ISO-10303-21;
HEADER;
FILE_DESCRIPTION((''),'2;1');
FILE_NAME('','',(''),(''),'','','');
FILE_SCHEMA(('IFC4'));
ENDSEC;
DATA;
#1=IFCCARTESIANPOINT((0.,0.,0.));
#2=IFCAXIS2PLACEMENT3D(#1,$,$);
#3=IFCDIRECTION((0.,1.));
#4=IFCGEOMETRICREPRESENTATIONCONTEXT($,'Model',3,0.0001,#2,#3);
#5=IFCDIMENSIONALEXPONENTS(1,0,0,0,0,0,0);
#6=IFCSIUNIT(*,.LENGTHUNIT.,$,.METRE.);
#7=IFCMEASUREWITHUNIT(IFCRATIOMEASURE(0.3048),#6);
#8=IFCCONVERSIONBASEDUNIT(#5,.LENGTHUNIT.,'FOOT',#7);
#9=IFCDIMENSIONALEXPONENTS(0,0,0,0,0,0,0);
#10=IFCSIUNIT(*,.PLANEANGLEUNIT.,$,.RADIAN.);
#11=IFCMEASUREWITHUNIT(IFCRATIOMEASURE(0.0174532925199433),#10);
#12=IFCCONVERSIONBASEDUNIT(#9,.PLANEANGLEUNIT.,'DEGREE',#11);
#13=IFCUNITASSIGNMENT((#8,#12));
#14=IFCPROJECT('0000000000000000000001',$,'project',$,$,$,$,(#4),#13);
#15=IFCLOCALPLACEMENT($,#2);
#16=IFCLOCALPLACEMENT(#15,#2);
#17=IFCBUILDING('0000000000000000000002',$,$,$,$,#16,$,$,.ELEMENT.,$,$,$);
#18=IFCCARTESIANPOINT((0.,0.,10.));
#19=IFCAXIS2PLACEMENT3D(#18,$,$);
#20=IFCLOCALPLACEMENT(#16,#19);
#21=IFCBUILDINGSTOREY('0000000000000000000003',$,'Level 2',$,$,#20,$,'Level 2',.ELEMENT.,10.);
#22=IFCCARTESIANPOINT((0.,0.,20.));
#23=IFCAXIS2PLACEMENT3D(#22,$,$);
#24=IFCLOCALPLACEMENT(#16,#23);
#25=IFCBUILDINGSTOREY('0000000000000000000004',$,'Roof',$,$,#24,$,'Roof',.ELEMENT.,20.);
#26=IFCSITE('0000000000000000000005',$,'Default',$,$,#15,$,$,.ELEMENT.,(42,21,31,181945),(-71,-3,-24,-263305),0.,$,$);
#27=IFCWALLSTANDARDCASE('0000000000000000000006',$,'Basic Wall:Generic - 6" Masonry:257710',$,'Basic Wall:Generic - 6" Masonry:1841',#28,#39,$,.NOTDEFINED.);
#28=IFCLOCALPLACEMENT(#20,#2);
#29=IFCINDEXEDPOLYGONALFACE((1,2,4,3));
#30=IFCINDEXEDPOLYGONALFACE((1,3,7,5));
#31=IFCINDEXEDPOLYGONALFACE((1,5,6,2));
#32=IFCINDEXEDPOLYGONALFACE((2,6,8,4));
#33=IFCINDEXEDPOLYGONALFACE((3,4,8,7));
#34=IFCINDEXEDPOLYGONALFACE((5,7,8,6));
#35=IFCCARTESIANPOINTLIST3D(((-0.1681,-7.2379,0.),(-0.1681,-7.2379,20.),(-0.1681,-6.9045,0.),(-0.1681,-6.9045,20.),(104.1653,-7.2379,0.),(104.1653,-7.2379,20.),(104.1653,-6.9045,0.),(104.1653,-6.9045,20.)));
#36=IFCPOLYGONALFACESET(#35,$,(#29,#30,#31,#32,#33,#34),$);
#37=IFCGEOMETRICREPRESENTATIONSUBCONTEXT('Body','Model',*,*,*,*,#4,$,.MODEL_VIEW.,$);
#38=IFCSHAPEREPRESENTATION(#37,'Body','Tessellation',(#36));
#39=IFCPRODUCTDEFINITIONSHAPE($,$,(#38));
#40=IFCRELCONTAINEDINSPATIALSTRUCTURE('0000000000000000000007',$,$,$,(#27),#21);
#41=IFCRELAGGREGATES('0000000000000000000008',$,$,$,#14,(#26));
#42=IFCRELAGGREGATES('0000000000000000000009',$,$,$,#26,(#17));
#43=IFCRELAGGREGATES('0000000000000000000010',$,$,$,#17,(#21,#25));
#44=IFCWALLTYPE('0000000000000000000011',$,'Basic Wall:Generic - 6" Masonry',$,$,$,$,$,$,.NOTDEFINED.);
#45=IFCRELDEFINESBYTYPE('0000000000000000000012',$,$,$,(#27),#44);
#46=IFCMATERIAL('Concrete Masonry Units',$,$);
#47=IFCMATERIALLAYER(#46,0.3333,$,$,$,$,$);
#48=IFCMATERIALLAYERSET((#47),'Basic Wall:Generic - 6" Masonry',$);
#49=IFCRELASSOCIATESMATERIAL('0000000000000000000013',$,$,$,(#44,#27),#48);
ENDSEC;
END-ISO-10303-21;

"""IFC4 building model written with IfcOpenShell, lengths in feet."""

from ifc_helpers import new_model, entity, si_unit, converted_unit, direction, frame, frame_2d, origin, place, context, subcontext, project, spatial, rectangle, extrude, material, layer, layer_set, layer_usage, type_object, element, save


model = new_model("IFC4")

# Units and contexts
model_context = context("Model", 3, precision=0.0001, world=origin(), true_north=direction((0.0, 1.0)))
body_context = subcontext(model_context, "Body", "Model", "MODEL_VIEW")
ifc_project = project(units=[converted_unit("LENGTHUNIT", "FOOT", entity("IfcRatioMeasure", 0.3048), si_unit("LENGTHUNIT", "METRE"), dimensions=[1, 0, 0, 0, 0, 0, 0]), converted_unit("PLANEANGLEUNIT", "DEGREE", entity("IfcRatioMeasure", 0.0174532925199433), si_unit("PLANEANGLEUNIT", "RADIAN"), dimensions=[0, 0, 0, 0, 0, 0, 0])], contexts=[model_context])

# Site, building, storey
site_placement = place(None, origin())
site = spatial("IfcSite", under=ifc_project, at=site_placement, Name="Default", CompositionType="ELEMENT", RefLatitude=(42, 21, 31, 181945), RefLongitude=(-71, -3, -24, -263305), RefElevation=0.0)
building_placement = place(site_placement, origin())
building = spatial("IfcBuilding", under=site, at=building_placement, CompositionType="ELEMENT")
storey_1_placement = place(building_placement, frame((0.0, 0.0, 10.0)))
storey_1 = spatial("IfcBuildingStorey", under=building, at=storey_1_placement, Name="Level 2", LongName="Level 2", CompositionType="ELEMENT", Elevation=10.0)

# Shared definitions
ifc_material_1 = material(Name="Concrete Masonry Units")
ifc_layer = layer(ifc_material_1, 0.3333)
ifc_layer_set = layer_set([ifc_layer], Name="Basic Wall:Generic - 6\" Masonry")
wall_type = type_object("IfcWallType", Name="Basic Wall:Generic - 6\" Masonry", PredefinedType="NOTDEFINED", material=ifc_layer_set)

# Shared definitions
storey_2_placement = place(building_placement, frame((0.0, 0.0, 20.0)))
storey_2 = spatial("IfcBuildingStorey", under=building, at=storey_2_placement, Name="Roof", LongName="Roof", CompositionType="ELEMENT", Elevation=20.0)

# Wall
ifc_layer_usage_1 = layer_usage(ifc_layer_set, "AXIS2", "NEGATIVE", 0.1667)
wall_1_placement = place(storey_1_placement, frame((104.1653, -7.0712, 0.0), z_axis=(0.0, 0.0, 1.0), x_axis=(-1.0, 0.0, 0.0)))
element("IfcWallStandardCase", 1, at=wall_1_placement, inside=storey_1, type_object=wall_type, material=ifc_layer_usage_1, Name="Basic Wall:Generic - 6\" Masonry:257710", ObjectType="Basic Wall:Generic - 6\" Masonry:1841", PredefinedType="NOTDEFINED", context=body_context, shape_type="SweptSolid", body=[
    extrude(rectangle(XDim=104.3333, YDim=0.3333, at=frame_2d((52.1667, 0.0), x_axis=(-1.0, 0.0))), origin(), (0.0, 0.0, 1.0), 20.0),
])

save(model, "model.ifc")
